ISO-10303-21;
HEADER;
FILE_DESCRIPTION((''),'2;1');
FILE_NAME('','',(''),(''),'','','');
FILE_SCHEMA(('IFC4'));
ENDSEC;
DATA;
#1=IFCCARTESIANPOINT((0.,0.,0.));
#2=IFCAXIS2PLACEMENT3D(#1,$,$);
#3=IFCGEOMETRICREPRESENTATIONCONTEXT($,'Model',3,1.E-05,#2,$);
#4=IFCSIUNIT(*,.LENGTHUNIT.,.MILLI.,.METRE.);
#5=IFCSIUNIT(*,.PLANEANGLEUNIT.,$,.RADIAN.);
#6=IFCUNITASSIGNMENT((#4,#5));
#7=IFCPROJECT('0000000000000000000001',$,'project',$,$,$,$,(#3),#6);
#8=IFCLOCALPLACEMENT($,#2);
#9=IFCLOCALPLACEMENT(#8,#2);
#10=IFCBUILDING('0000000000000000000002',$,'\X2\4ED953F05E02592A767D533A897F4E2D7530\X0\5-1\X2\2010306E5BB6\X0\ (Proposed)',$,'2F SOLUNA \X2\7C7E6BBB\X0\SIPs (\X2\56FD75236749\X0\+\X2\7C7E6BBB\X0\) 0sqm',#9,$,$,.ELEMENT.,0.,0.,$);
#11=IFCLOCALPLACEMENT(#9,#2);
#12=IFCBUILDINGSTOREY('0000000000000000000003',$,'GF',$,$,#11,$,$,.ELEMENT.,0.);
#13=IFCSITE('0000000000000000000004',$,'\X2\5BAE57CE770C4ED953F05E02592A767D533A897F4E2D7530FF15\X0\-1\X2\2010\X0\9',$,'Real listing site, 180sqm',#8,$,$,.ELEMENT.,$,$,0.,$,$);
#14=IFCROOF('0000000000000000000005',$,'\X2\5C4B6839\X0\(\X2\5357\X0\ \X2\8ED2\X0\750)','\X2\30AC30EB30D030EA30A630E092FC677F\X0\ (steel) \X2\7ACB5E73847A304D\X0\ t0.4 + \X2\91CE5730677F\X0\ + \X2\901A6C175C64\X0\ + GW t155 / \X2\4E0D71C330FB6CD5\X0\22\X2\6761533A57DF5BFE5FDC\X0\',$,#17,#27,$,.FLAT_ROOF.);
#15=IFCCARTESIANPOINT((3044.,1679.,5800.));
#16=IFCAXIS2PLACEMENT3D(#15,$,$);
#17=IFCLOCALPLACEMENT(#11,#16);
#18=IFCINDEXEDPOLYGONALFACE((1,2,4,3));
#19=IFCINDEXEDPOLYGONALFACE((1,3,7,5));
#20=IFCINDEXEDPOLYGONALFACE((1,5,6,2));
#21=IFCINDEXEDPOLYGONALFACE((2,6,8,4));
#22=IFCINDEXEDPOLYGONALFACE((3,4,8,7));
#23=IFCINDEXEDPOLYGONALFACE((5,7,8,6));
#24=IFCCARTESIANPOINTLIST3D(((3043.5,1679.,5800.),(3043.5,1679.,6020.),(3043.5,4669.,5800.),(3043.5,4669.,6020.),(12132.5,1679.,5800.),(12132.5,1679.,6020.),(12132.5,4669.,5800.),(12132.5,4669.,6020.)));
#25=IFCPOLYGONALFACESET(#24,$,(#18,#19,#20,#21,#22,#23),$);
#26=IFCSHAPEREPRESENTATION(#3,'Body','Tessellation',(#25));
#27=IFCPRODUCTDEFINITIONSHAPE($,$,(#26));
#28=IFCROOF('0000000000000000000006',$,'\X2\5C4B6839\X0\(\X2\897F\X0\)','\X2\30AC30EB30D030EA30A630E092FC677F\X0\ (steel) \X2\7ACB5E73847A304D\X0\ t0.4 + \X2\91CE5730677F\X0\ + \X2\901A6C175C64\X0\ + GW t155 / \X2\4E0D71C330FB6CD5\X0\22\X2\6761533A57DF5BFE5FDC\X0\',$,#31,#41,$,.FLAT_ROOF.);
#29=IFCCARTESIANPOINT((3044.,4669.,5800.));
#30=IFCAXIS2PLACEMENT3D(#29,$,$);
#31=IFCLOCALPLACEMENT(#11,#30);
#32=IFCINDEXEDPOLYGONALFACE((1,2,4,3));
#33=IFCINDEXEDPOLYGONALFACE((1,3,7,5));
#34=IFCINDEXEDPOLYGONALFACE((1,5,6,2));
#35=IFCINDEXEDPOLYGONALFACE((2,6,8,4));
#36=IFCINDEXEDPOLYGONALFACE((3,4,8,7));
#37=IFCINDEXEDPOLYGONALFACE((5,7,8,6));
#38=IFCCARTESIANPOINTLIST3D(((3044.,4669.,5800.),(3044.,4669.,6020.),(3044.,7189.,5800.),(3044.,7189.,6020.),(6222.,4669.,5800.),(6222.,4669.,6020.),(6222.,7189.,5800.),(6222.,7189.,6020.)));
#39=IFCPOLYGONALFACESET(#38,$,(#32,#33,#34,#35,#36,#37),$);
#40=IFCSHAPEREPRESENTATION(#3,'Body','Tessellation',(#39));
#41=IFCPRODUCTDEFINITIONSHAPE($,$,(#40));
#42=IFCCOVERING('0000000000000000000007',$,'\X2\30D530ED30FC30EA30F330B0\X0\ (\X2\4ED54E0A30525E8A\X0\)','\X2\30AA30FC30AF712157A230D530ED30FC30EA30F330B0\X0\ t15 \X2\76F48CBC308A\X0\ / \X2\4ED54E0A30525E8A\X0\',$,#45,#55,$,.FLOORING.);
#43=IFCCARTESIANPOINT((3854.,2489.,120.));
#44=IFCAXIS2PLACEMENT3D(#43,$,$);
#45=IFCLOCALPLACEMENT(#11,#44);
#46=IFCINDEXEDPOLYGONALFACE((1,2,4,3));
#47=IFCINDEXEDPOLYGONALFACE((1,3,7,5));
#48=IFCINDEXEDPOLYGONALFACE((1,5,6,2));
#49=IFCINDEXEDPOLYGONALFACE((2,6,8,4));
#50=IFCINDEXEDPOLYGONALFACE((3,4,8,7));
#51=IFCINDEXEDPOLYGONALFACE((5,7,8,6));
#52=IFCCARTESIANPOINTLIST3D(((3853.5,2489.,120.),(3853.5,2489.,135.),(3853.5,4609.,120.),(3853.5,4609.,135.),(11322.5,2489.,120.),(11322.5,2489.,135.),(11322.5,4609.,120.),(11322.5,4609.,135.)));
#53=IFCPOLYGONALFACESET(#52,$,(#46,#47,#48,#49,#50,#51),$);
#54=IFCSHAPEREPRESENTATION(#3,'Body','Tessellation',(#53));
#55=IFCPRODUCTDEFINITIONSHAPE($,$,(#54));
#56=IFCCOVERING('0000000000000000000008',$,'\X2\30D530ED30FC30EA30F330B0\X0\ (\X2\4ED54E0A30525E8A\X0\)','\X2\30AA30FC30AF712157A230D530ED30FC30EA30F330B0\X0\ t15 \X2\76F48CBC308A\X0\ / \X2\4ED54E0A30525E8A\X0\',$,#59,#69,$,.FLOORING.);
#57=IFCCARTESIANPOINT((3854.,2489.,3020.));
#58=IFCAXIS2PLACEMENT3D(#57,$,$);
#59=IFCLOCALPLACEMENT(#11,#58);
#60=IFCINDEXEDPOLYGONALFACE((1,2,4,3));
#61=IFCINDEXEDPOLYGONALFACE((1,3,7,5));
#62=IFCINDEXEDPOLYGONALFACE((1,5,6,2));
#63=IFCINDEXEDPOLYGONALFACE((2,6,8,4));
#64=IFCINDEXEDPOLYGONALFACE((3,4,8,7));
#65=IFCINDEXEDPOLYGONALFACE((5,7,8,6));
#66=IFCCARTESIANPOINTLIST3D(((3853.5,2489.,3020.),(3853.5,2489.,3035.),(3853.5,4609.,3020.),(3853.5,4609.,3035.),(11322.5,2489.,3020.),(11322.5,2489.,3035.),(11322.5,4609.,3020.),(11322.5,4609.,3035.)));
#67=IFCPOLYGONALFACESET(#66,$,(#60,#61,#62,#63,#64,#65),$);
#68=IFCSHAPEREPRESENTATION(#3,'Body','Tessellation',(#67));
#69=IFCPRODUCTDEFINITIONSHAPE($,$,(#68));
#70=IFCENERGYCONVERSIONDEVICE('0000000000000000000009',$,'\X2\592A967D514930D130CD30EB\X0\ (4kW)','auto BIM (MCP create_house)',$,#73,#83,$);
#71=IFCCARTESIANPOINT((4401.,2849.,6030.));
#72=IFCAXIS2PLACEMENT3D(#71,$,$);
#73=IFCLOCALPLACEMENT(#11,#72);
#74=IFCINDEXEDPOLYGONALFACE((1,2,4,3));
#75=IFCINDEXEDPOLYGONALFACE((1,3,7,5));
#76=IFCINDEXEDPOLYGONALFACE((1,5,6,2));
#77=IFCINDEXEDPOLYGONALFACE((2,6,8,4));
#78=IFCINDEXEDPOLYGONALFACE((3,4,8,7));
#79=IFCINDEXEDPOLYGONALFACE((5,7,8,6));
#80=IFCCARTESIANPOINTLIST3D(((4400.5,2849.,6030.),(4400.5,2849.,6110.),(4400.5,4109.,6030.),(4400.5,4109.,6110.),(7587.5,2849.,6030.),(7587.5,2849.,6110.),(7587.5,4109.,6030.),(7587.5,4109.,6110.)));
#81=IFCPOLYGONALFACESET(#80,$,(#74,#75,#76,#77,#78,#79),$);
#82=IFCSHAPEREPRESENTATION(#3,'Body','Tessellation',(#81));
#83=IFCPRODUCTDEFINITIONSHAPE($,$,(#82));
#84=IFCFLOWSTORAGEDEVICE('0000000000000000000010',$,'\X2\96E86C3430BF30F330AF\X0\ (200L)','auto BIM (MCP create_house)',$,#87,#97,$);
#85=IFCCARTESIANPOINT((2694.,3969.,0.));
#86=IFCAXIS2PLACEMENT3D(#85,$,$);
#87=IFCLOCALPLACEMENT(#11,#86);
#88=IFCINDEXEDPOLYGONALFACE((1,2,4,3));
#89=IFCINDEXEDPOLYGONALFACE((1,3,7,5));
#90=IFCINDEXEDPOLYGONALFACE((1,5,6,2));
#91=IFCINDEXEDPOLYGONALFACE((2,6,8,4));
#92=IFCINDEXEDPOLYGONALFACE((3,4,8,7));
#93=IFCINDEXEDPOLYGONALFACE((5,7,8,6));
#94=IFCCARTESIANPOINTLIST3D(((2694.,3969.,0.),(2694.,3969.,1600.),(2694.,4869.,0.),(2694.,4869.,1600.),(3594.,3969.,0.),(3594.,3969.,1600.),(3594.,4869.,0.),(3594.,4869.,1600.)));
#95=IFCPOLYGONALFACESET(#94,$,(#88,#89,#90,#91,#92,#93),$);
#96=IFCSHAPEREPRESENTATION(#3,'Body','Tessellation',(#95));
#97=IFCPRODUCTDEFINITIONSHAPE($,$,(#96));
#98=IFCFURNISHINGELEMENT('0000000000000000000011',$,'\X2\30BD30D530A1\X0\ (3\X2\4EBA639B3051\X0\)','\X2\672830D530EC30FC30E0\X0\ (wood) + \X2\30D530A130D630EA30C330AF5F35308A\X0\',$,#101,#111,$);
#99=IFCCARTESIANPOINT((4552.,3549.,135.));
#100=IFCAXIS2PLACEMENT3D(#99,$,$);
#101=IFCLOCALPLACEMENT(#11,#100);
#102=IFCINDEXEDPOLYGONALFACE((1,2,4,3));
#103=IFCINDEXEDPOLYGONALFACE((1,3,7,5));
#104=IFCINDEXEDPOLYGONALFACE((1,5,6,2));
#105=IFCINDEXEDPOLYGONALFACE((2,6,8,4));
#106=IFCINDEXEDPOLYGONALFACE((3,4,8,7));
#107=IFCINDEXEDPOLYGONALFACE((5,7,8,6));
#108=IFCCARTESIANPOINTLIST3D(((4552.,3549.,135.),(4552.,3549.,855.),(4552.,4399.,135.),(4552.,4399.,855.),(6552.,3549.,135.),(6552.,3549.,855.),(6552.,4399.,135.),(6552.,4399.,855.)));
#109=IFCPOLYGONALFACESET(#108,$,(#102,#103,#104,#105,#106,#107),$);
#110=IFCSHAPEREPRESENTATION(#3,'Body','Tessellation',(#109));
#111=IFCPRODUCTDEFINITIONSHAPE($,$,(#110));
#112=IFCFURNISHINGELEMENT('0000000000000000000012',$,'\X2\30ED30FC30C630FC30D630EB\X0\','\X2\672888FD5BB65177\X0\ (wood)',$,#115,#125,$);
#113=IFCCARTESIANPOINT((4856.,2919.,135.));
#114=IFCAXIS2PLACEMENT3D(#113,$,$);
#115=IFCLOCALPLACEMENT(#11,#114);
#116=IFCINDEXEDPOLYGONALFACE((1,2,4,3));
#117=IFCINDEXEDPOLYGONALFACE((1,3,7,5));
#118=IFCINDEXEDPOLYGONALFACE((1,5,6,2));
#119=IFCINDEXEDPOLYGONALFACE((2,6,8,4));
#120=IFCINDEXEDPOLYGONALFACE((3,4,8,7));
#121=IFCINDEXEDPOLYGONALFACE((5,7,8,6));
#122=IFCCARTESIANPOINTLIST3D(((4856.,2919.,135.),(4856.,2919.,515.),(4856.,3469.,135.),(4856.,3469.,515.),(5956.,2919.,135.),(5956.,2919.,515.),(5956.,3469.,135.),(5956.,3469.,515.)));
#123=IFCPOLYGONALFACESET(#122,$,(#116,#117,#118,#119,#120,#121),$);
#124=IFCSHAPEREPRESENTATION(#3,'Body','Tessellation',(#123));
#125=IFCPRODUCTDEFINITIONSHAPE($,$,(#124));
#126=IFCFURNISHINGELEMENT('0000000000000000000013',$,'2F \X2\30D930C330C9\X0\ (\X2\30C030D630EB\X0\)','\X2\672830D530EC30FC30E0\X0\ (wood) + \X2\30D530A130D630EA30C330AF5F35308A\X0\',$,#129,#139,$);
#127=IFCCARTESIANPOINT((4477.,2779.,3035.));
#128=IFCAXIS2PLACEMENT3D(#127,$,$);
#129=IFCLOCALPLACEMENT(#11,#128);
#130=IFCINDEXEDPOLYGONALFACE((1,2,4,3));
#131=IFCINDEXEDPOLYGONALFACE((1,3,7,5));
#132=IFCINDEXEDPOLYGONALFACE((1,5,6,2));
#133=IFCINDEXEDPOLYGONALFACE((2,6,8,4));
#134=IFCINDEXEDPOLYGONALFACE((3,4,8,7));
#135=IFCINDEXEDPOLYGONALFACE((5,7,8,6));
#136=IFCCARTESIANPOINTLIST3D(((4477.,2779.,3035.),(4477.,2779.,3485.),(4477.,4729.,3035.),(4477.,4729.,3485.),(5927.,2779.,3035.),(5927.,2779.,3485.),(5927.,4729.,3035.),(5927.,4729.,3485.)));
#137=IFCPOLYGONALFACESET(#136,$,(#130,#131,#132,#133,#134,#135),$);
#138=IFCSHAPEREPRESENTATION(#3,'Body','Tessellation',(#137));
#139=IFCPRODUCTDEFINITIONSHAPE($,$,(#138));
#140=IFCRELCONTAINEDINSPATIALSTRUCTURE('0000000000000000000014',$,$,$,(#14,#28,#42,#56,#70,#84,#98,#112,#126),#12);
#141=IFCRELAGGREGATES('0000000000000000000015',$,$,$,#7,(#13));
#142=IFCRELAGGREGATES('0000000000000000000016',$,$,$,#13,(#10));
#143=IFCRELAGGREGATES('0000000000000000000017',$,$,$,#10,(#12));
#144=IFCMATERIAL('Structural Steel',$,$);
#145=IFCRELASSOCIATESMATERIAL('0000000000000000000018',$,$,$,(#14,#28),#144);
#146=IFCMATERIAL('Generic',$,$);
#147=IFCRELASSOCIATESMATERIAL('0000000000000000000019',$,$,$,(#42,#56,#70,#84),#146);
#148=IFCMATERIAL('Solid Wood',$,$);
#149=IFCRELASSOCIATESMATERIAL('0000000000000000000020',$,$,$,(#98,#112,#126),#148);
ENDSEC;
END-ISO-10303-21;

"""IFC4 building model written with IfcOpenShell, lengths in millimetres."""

from ifc_helpers import new_model, si_unit, frame, frame_2d, origin, place, context, project, spatial, rectangle, extrude, material, element, save


model = new_model("IFC4")

# Units and contexts
model_context = context("Model", 3, precision=1e-05, world=origin())
ifc_project = project(units=[si_unit("LENGTHUNIT", "METRE", prefix="MILLI"), si_unit("PLANEANGLEUNIT", "RADIAN")], contexts=[model_context])

# Site, building, storey
site_placement = place(None, origin())
site = spatial("IfcSite", under=ifc_project, at=site_placement, Name="宮城県仙台市太白区西中田５-1‐9", ObjectType="Real listing site, 180sqm", CompositionType="ELEMENT", RefElevation=0.0)
building_placement = place(site_placement, origin())
building = spatial("IfcBuilding", under=site, at=building_placement, Name="仙台市太白区西中田5-1‐の家 (Proposed)", ObjectType="2F SOLUNA 籾殻SIPs (国産杉+籾殻) 0sqm", CompositionType="ELEMENT", ElevationOfRefHeight=0.0, ElevationOfTerrain=0.0)
storey_placement = place(building_placement, origin())
storey = spatial("IfcBuildingStorey", under=building, at=storey_placement, Name="GF", CompositionType="ELEMENT", Elevation=0.0)

# Shared definitions
ifc_material_1 = material(Name="Solid Wood")

# Roofs
ifc_material_2 = material(Name="Structural Steel")
roof_1_placement = place(storey_placement, frame((3044.0, 1679.0, 5800.0)))
element("IfcRoof", 1, at=roof_1_placement, inside=storey, material=ifc_material_2, Name="屋根(南 軒750)", Description="ガルバリウム鋼板 (steel) 立平葺き t0.4 + 野地板 + 通気層 + GW t155 / 不燃・法22条区域対応", PredefinedType="FLAT_ROOF", context=model_context, shape_type="SweptSolid", body=[
    extrude(rectangle(XDim=9089.0, YDim=2990.0, at=frame_2d((4544.0, 1495.0))), frame((3044.0, 1679.0, 5800.0)), (0.0, 0.0, 1.0), 220.0),
])
roof_2_placement = place(storey_placement, frame((3044.0, 4669.0, 5800.0)))
element("IfcRoof", 2, at=roof_2_placement, inside=storey, material=ifc_material_2, Name="屋根(西)", Description="ガルバリウム鋼板 (steel) 立平葺き t0.4 + 野地板 + 通気層 + GW t155 / 不燃・法22条区域対応", PredefinedType="FLAT_ROOF", context=model_context, shape_type="SweptSolid", body=[
    extrude(rectangle(XDim=3178.0, YDim=2520.0, at=frame_2d((1589.0, 1260.0))), frame((3044.0, 4669.0, 5800.0)), (0.0, 0.0, 1.0), 220.0),
])

# Coverings
ifc_material_3 = material(Name="Generic")
covering_1_placement = place(storey_placement, frame((3854.0, 2489.0, 120.0)))
element("IfcCovering", 3, at=covering_1_placement, inside=storey, material=ifc_material_3, Name="フローリング (仕上げ床)", Description="オーク無垢フローリング t15 直貼り / 仕上げ床", PredefinedType="FLOORING", context=model_context, shape_type="SweptSolid", body=[
    extrude(rectangle(XDim=7469.0, YDim=2120.0, at=frame_2d((3734.0, 1060.0))), frame((3854.0, 2489.0, 120.0)), (0.0, 0.0, 1.0), 15.0),
])
covering_2_placement = place(storey_placement, frame((3854.0, 2489.0, 3020.0)))
element("IfcCovering", 4, at=covering_2_placement, inside=storey, material=ifc_material_3, Name="フローリング (仕上げ床)", Description="オーク無垢フローリング t15 直貼り / 仕上げ床", PredefinedType="FLOORING", context=model_context, shape_type="SweptSolid", body=[
    extrude(rectangle(XDim=7469.0, YDim=2120.0, at=frame_2d((3734.0, 1060.0))), frame((3854.0, 2489.0, 3020.0)), (0.0, 0.0, 1.0), 15.0),
])

# Energy conversion device
energy_conversion_device_placement = place(storey_placement, frame((4401.0, 2849.0, 6030.0)))
element("IfcEnergyConversionDevice", 5, at=energy_conversion_device_placement, inside=storey, material=ifc_material_3, Name="太陽光パネル (4kW)", Description="auto BIM (MCP create_house)", context=model_context, shape_type="SweptSolid", body=[
    extrude(rectangle(XDim=3187.0, YDim=1260.0, at=frame_2d((1593.0, 630.0))), frame((4401.0, 2849.0, 6030.0)), (0.0, 0.0, 1.0), 80.0),
])

# Flow storage device
flow_storage_device_placement = place(storey_placement, frame((2694.0, 3969.0, 0.0)))
element("IfcFlowStorageDevice", 6, at=flow_storage_device_placement, inside=storey, material=ifc_material_3, Name="雨水タンク (200L)", Description="auto BIM (MCP create_house)", context=model_context, shape_type="SweptSolid", body=[
    extrude(rectangle(XDim=900.0, YDim=900.0, at=frame_2d((450.0, 450.0))), frame((2694.0, 3969.0, 0.0)), (0.0, 0.0, 1.0), 1600.0),
])

# Furnishing elements
furnishing_1_placement = place(storey_placement, frame((4552.0, 3549.0, 135.0)))
element("IfcFurnishingElement", 7, at=furnishing_1_placement, inside=storey, material=ifc_material_1, Name="ソファ (3人掛け)", Description="木フレーム (wood) + ファブリック張り", context=model_context, shape_type="SweptSolid", body=[
    extrude(rectangle(XDim=2000.0, YDim=850.0, at=frame_2d((1000.0, 425.0))), frame((4552.0, 3549.0, 135.0)), (0.0, 0.0, 1.0), 720.0),
])
furnishing_2_placement = place(storey_placement, frame((4856.0, 2919.0, 135.0)))
element("IfcFurnishingElement", 8, at=furnishing_2_placement, inside=storey, material=ifc_material_1, Name="ローテーブル", Description="木製家具 (wood)", context=model_context, shape_type="SweptSolid", body=[
    extrude(rectangle(XDim=1100.0, YDim=550.0, at=frame_2d((550.0, 275.0))), frame((4856.0, 2919.0, 135.0)), (0.0, 0.0, 1.0), 380.0),
])
furnishing_3_placement = place(storey_placement, frame((4477.0, 2779.0, 3035.0)))
element("IfcFurnishingElement", 9, at=furnishing_3_placement, inside=storey, material=ifc_material_1, Name="2F ベッド (ダブル)", Description="木フレーム (wood) + ファブリック張り", context=model_context, shape_type="SweptSolid", body=[
    extrude(rectangle(XDim=1450.0, YDim=1950.0, at=frame_2d((725.0, 975.0))), frame((4477.0, 2779.0, 3035.0)), (0.0, 0.0, 1.0), 450.0),
])

save(model, "model.ifc")
